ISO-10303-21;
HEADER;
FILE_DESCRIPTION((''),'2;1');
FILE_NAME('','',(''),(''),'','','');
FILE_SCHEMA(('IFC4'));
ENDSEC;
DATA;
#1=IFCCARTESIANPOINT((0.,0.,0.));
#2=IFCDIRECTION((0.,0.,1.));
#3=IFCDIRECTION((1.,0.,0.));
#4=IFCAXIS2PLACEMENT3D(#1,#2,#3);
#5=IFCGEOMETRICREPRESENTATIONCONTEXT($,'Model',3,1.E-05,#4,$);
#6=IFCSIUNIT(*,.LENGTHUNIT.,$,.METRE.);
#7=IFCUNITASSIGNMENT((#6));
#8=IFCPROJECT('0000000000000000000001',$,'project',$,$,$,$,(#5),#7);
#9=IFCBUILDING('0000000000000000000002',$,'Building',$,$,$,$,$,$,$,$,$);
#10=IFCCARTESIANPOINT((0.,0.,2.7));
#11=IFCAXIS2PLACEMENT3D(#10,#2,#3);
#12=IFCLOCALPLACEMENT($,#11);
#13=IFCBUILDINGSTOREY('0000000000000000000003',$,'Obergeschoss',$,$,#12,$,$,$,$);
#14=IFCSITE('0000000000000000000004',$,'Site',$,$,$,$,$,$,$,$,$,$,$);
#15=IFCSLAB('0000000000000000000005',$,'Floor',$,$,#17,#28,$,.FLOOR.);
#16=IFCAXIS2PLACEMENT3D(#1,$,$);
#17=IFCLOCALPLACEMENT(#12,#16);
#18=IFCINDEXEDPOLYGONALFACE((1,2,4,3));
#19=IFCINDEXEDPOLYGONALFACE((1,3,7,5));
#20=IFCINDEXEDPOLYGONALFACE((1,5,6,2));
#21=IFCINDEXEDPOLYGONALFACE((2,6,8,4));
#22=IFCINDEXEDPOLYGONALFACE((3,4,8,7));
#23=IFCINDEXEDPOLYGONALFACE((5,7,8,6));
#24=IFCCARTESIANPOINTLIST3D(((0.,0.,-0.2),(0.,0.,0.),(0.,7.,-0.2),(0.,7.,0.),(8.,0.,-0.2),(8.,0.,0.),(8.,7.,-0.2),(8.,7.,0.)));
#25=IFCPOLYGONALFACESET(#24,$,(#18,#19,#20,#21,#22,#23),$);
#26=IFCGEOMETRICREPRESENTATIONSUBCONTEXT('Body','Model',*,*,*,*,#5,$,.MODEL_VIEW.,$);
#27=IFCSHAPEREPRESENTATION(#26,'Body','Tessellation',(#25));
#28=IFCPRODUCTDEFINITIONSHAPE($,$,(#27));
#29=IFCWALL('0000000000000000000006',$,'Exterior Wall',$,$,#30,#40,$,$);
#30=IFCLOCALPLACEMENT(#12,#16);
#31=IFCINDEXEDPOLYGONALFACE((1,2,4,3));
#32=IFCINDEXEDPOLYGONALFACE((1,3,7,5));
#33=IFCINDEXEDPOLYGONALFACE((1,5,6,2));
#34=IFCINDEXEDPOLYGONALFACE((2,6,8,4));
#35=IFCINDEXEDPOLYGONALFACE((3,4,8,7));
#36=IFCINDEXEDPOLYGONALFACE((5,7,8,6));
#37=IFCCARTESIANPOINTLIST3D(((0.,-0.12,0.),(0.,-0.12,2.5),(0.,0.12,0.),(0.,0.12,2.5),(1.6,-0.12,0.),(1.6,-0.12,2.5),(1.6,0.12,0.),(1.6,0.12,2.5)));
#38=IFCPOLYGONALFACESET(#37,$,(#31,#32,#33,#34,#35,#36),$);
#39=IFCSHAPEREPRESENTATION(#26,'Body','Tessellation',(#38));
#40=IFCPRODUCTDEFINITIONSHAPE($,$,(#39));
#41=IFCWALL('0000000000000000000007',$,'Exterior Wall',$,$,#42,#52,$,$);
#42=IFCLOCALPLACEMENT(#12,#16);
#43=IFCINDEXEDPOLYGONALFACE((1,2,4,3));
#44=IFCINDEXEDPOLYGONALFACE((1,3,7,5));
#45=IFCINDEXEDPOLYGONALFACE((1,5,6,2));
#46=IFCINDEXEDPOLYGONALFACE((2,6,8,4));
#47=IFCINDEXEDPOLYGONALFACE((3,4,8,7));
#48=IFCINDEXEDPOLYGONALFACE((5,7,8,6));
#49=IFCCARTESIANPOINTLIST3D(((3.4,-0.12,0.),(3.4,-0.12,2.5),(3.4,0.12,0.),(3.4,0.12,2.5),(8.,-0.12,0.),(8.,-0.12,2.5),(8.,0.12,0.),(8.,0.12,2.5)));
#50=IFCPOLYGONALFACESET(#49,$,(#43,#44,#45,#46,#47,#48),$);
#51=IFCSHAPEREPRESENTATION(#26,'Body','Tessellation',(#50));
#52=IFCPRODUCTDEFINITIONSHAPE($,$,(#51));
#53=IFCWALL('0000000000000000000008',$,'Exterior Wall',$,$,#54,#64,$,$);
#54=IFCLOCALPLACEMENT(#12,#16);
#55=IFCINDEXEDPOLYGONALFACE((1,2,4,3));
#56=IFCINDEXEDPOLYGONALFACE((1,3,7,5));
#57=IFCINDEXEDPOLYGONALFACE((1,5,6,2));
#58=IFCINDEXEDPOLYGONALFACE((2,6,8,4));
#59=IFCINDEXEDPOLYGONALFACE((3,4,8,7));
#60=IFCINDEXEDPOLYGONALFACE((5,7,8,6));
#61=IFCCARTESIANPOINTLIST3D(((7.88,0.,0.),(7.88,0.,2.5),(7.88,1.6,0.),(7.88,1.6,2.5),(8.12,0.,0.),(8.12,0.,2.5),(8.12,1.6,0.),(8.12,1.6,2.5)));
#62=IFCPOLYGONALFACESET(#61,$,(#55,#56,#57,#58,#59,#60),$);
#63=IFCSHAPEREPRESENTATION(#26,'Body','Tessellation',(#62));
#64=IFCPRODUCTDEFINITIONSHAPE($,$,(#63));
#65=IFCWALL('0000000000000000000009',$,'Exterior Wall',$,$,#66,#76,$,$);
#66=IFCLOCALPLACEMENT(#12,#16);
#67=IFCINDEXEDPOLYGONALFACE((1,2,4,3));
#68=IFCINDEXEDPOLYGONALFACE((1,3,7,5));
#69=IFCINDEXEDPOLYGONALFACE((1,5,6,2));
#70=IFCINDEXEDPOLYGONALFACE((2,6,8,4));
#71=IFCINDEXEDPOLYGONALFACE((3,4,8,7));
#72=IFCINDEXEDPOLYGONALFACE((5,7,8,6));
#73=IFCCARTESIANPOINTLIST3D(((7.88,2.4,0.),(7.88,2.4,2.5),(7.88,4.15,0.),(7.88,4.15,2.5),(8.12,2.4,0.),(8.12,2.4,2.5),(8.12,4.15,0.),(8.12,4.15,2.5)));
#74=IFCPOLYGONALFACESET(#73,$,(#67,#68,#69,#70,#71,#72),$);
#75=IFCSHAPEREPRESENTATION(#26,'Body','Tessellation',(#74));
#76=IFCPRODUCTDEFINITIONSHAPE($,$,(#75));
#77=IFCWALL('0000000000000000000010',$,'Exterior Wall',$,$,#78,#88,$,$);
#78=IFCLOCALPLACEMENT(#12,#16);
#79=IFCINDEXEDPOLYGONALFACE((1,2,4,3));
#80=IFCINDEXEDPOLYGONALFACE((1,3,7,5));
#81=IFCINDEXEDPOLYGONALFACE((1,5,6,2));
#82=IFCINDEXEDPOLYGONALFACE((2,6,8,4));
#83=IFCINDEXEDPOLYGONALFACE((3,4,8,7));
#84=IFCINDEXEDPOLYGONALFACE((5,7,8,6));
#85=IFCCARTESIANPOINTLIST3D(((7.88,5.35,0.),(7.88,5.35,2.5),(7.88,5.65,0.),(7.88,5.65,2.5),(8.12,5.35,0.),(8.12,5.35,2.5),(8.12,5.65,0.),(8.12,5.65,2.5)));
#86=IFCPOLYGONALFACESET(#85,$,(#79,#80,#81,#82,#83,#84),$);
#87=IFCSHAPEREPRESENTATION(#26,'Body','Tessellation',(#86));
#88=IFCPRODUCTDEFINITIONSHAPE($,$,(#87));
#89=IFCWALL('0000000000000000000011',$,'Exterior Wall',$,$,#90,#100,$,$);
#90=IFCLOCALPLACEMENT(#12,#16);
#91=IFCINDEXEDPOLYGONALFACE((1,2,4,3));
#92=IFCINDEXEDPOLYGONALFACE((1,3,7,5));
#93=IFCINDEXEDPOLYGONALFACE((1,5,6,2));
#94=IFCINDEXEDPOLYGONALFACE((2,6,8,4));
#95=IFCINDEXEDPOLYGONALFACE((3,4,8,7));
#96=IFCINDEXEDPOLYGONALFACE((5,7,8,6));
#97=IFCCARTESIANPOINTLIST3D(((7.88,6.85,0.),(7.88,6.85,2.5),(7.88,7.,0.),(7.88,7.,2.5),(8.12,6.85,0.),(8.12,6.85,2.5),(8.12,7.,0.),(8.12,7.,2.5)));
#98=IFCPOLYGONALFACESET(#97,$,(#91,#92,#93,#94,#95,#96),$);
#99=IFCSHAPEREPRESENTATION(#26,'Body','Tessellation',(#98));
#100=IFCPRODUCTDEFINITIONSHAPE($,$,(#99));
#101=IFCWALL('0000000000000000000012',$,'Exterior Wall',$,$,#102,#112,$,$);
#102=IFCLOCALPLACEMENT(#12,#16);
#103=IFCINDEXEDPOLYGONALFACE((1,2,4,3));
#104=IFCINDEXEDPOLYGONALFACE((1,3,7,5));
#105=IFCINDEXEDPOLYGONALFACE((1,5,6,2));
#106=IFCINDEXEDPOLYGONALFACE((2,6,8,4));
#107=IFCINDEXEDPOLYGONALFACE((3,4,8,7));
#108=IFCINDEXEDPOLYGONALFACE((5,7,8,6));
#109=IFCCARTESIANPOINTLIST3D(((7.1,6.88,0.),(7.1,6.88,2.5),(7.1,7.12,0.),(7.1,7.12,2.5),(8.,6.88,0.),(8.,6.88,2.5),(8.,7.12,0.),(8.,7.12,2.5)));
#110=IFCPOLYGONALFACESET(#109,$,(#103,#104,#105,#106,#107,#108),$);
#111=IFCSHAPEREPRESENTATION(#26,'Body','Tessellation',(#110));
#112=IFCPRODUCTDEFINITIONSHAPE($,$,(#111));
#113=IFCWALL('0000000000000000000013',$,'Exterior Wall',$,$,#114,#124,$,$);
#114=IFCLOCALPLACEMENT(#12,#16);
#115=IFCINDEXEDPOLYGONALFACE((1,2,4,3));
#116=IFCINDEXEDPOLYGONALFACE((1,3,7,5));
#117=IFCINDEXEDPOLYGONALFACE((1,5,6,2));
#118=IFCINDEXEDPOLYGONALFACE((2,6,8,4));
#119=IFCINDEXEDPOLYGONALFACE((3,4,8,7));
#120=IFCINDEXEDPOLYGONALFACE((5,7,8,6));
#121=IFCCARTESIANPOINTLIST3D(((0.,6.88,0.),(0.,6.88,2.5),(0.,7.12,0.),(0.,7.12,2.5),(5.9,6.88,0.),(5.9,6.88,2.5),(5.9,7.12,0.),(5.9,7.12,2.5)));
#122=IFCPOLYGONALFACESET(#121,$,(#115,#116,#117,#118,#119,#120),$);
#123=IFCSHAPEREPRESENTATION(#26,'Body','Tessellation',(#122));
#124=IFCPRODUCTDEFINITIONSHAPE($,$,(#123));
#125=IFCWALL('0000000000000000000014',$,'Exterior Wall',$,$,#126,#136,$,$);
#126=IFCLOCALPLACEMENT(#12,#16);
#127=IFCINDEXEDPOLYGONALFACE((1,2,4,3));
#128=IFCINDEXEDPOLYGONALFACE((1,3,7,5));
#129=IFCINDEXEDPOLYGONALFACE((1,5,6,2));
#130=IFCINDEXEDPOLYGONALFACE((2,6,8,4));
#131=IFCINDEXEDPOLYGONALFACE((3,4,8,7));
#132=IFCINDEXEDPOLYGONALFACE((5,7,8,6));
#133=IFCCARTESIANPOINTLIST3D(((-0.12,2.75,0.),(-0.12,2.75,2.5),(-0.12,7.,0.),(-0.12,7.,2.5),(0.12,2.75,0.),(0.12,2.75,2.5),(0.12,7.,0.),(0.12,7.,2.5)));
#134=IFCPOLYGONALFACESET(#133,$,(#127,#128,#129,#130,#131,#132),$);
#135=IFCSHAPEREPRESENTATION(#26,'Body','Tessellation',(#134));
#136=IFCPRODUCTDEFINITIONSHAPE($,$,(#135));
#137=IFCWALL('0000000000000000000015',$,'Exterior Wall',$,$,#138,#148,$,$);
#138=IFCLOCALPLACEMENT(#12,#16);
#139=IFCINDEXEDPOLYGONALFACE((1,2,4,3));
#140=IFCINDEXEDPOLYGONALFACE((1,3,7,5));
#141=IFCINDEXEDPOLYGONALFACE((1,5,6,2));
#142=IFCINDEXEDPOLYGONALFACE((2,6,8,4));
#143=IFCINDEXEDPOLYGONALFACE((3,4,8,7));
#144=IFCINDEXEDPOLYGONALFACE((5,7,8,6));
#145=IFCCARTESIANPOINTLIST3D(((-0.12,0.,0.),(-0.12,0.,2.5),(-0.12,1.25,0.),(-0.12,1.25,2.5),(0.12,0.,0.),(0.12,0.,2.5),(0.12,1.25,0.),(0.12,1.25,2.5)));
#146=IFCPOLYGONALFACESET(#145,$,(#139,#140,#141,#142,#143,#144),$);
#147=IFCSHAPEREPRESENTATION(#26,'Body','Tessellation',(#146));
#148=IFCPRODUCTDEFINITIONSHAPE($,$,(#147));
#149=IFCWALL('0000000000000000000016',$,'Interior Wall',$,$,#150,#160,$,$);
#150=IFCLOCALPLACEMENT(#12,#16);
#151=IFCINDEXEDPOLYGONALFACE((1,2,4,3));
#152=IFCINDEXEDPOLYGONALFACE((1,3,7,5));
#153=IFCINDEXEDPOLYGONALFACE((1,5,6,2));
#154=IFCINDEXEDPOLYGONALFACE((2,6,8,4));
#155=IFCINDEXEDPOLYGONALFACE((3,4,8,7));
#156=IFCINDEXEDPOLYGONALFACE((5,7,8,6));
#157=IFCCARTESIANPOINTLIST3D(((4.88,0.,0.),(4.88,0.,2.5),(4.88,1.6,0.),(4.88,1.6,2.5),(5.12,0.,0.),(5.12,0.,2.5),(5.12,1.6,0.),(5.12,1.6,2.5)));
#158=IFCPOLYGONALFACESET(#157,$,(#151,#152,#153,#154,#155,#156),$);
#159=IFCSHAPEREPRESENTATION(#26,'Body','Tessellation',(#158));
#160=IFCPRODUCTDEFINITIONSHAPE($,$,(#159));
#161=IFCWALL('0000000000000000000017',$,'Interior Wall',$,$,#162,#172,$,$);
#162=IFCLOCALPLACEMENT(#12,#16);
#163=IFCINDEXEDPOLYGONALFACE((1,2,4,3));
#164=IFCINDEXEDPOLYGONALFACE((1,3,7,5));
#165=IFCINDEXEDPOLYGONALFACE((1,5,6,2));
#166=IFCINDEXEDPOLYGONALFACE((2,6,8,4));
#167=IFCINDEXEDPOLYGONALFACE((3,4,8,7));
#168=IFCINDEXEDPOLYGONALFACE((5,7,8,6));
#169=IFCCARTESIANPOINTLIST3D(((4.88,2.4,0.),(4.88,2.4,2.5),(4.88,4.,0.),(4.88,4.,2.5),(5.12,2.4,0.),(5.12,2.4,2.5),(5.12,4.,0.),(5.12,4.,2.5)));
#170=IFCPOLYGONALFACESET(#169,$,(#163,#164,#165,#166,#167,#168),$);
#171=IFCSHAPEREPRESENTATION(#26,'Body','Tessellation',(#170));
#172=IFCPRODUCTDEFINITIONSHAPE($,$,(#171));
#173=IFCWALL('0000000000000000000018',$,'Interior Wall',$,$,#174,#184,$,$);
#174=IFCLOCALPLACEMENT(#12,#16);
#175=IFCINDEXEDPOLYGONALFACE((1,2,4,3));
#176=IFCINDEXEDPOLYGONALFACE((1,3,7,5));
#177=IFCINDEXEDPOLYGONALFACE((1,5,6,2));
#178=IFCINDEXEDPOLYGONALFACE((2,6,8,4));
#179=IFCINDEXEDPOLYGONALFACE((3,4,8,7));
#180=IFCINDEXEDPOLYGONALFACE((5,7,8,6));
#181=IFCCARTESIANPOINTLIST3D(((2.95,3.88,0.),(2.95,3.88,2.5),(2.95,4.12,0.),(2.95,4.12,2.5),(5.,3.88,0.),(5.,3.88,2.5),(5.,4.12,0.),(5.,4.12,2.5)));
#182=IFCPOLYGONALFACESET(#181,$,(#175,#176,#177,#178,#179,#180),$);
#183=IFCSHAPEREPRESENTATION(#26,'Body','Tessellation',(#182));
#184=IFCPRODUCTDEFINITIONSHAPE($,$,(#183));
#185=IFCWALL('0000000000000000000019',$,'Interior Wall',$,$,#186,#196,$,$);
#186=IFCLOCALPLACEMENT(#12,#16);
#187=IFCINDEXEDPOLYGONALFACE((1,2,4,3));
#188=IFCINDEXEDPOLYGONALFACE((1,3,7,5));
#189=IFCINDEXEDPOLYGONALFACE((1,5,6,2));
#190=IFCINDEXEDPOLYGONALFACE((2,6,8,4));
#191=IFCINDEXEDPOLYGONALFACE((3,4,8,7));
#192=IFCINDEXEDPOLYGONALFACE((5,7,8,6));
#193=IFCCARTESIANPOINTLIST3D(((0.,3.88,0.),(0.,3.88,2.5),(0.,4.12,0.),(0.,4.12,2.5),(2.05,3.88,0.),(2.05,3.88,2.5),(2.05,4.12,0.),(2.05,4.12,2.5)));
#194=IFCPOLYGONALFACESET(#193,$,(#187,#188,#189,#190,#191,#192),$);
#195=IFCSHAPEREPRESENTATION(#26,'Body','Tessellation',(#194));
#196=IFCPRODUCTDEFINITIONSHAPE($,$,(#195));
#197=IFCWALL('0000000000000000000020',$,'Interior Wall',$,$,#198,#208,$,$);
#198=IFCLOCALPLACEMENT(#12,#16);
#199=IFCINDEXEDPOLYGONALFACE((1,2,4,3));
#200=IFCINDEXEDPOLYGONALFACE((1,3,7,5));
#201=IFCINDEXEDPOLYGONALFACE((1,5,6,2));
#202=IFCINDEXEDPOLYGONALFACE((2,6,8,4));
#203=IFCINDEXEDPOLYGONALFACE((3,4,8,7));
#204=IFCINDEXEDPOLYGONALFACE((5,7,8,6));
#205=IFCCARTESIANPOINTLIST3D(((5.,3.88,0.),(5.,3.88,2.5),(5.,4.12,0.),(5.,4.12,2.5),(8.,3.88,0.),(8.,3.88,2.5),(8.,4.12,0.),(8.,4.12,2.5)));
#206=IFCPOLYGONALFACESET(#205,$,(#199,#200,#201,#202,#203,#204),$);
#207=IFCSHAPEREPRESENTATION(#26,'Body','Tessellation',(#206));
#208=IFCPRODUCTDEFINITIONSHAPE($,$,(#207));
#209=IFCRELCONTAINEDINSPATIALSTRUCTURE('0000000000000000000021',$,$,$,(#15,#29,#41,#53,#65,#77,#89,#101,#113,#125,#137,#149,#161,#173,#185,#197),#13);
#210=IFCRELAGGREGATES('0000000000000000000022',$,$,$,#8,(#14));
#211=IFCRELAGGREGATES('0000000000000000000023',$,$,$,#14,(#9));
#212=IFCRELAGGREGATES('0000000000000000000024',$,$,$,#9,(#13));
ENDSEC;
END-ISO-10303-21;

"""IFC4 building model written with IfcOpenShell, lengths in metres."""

from ifc_helpers import new_model, si_unit, frame, origin_with_axes, place, context, subcontext, project, spatial, indexed_curve, outline, extrude, element, save


model = new_model("IFC4")

# Units and contexts
model_context = context("Model", 3, precision=1e-05, world=origin_with_axes())
body_context = subcontext(model_context, "Body", "Model", "MODEL_VIEW")
ifc_project = project(units=[si_unit("LENGTHUNIT", "METRE")], contexts=[model_context])

# Site, building, storey
site = spatial("IfcSite", under=ifc_project, Name="Site")
building = spatial("IfcBuilding", under=site, Name="Building")
storey_placement = place(None, frame((0.0, 0.0, 2.7), z_axis=(0.0, 0.0, 1.0), x_axis=(1.0, 0.0, 0.0)))
storey = spatial("IfcBuildingStorey", under=building, at=storey_placement, Name="Obergeschoss")

# Slab
slab_placement = place(storey_placement, frame((0.0, 0.0, -0.2), z_axis=(0.0, 0.0, 1.0), x_axis=(1.0, 0.0, 0.0)))
element("IfcSlab", 1, at=slab_placement, inside=storey, Name="Floor", PredefinedType="FLOOR", context=body_context, shape_type="SweptSolid", body=[
    extrude(outline(indexed_curve([(0.0, 0.0), (8.0, 0.0), (8.0, 7.0), (0.0, 7.0)])), None, (0.0, 0.0, 1.0), 0.2),
])

# Walls
wall_1_placement = place(storey_placement, origin_with_axes())
element("IfcWall", 2, at=wall_1_placement, inside=storey, Name="Exterior Wall", context=body_context, shape_type="SweptSolid", body=[
    extrude(outline(indexed_curve([(0.0, 0.0), (0.0, 0.24), (1.6, 0.24), (1.6, 0.0), (0.0, 0.0)], self_intersect=False)), frame((0.0, -0.12, 0.0), z_axis=(0.0, 0.0, 1.0), x_axis=(1.0, 0.0, 0.0)), (0.0, 0.0, 1.0), 2.5),
])
wall_2_placement = place(storey_placement, frame((3.4, 0.0, 0.0), z_axis=(0.0, 0.0, 1.0), x_axis=(1.0, 0.0, 0.0)))
element("IfcWall", 3, at=wall_2_placement, inside=storey, Name="Exterior Wall", context=body_context, shape_type="SweptSolid", body=[
    extrude(outline(indexed_curve([(0.0, 0.0), (0.0, 0.24), (4.6, 0.24), (4.6, 0.0), (0.0, 0.0)], self_intersect=False)), frame((0.0, -0.12, 0.0), z_axis=(0.0, 0.0, 1.0), x_axis=(1.0, 0.0, 0.0)), (0.0, 0.0, 1.0), 2.5),
])
wall_3_placement = place(storey_placement, frame((8.0, 0.0, 0.0), z_axis=(0.0, 0.0, 1.0), x_axis=(0.0, 1.0, 0.0)))
element("IfcWall", 4, at=wall_3_placement, inside=storey, Name="Exterior Wall", context=body_context, shape_type="SweptSolid", body=[
    extrude(outline(indexed_curve([(0.0, 0.0), (0.0, 0.24), (1.6, 0.24), (1.6, 0.0), (0.0, 0.0)], self_intersect=False)), frame((0.0, -0.12, 0.0), z_axis=(0.0, 0.0, 1.0), x_axis=(1.0, 0.0, 0.0)), (0.0, 0.0, 1.0), 2.5),
])
wall_4_placement = place(storey_placement, frame((8.0, 2.4, 0.0), z_axis=(0.0, 0.0, 1.0), x_axis=(0.0, 1.0, 0.0)))
element("IfcWall", 5, at=wall_4_placement, inside=storey, Name="Exterior Wall", context=body_context, shape_type="SweptSolid", body=[
    extrude(outline(indexed_curve([(0.0, 0.0), (0.0, 0.24), (1.75, 0.24), (1.75, 0.0), (0.0, 0.0)], self_intersect=False)), frame((0.0, -0.12, 0.0), z_axis=(0.0, 0.0, 1.0), x_axis=(1.0, 0.0, 0.0)), (0.0, 0.0, 1.0), 2.5),
])
wall_5_placement = place(storey_placement, frame((8.0, 5.35, 0.0), z_axis=(0.0, 0.0, 1.0), x_axis=(0.0, 1.0, 0.0)))
element("IfcWall", 6, at=wall_5_placement, inside=storey, Name="Exterior Wall", context=body_context, shape_type="SweptSolid", body=[
    extrude(outline(indexed_curve([(0.0, 0.0), (0.0, 0.24), (0.3, 0.24), (0.3, 0.0), (0.0, 0.0)], self_intersect=False)), frame((0.0, -0.12, 0.0), z_axis=(0.0, 0.0, 1.0), x_axis=(1.0, 0.0, 0.0)), (0.0, 0.0, 1.0), 2.5),
])
wall_6_placement = place(storey_placement, frame((8.0, 6.85, 0.0), z_axis=(0.0, 0.0, 1.0), x_axis=(0.0, 1.0, 0.0)))
element("IfcWall", 7, at=wall_6_placement, inside=storey, Name="Exterior Wall", context=body_context, shape_type="SweptSolid", body=[
    extrude(outline(indexed_curve([(0.0, 0.0), (0.0, 0.24), (0.15, 0.24), (0.15, 0.0), (0.0, 0.0)], self_intersect=False)), frame((0.0, -0.12, 0.0), z_axis=(0.0, 0.0, 1.0), x_axis=(1.0, 0.0, 0.0)), (0.0, 0.0, 1.0), 2.5),
])
wall_7_placement = place(storey_placement, frame((8.0, 7.0, 0.0), z_axis=(0.0, 0.0, 1.0), x_axis=(-1.0, 0.0, 0.0)))
element("IfcWall", 8, at=wall_7_placement, inside=storey, Name="Exterior Wall", context=body_context, shape_type="SweptSolid", body=[
    extrude(outline(indexed_curve([(0.0, 0.0), (0.0, 0.24), (0.9, 0.24), (0.9, 0.0), (0.0, 0.0)], self_intersect=False)), frame((0.0, -0.12, 0.0), z_axis=(0.0, 0.0, 1.0), x_axis=(1.0, 0.0, 0.0)), (0.0, 0.0, 1.0), 2.5),
])
wall_8_placement = place(storey_placement, frame((5.9, 7.0, 0.0), z_axis=(0.0, 0.0, 1.0), x_axis=(-1.0, 0.0, 0.0)))
element("IfcWall", 9, at=wall_8_placement, inside=storey, Name="Exterior Wall", context=body_context, shape_type="SweptSolid", body=[
    extrude(outline(indexed_curve([(0.0, 0.0), (0.0, 0.24), (5.9, 0.24), (5.9, 0.0), (0.0, 0.0)], self_intersect=False)), frame((0.0, -0.12, 0.0), z_axis=(0.0, 0.0, 1.0), x_axis=(1.0, 0.0, 0.0)), (0.0, 0.0, 1.0), 2.5),
])
wall_9_placement = place(storey_placement, frame((0.0, 7.0, 0.0), z_axis=(0.0, 0.0, 1.0), x_axis=(0.0, -1.0, 0.0)))
element("IfcWall", 10, at=wall_9_placement, inside=storey, Name="Exterior Wall", context=body_context, shape_type="SweptSolid", body=[
    extrude(outline(indexed_curve([(0.0, 0.0), (0.0, 0.24), (4.25, 0.24), (4.25, 0.0), (0.0, 0.0)], self_intersect=False)), frame((0.0, -0.12, 0.0), z_axis=(0.0, 0.0, 1.0), x_axis=(1.0, 0.0, 0.0)), (0.0, 0.0, 1.0), 2.5),
])
wall_10_placement = place(storey_placement, frame((0.0, 1.25, 0.0), z_axis=(0.0, 0.0, 1.0), x_axis=(0.0, -1.0, 0.0)))
element("IfcWall", 11, at=wall_10_placement, inside=storey, Name="Exterior Wall", context=body_context, shape_type="SweptSolid", body=[
    extrude(outline(indexed_curve([(0.0, 0.0), (0.0, 0.24), (1.25, 0.24), (1.25, 0.0), (0.0, 0.0)], self_intersect=False)), frame((0.0, -0.12, 0.0), z_axis=(0.0, 0.0, 1.0), x_axis=(1.0, 0.0, 0.0)), (0.0, 0.0, 1.0), 2.5),
])
for number, where, z_axis, x_axis, name in (
    (12, (5.0, 0.0, 0.0), (0.0, 0.0, 1.0), (0.0, 1.0, 0.0), "Interior Wall"),
    (13, (5.0, 2.4, 0.0), (0.0, 0.0, 1.0), (0.0, 1.0, 0.0), "Interior Wall"),
):
    element("IfcWall", number, at=place(storey_placement, frame(where, z_axis=z_axis, x_axis=x_axis)), inside=storey, Name=name, context=body_context, shape_type="SweptSolid", body=[
        extrude(outline(indexed_curve([(0.0, 0.0), (0.0, 0.24), (1.6, 0.24), (1.6, 0.0), (0.0, 0.0)], self_intersect=False)), frame((0.0, -0.12, 0.0), z_axis=(0.0, 0.0, 1.0), x_axis=(1.0, 0.0, 0.0)), (0.0, 0.0, 1.0), 2.5),
    ])
for number, where, z_axis, x_axis, name in (
    (14, (5.0, 4.0, 0.0), (0.0, 0.0, 1.0), (-1.0, 0.0, 0.0), "Interior Wall"),
    (15, (2.05, 4.0, 0.0), (0.0, 0.0, 1.0), (-1.0, 0.0, 0.0), "Interior Wall"),
):
    element("IfcWall", number, at=place(storey_placement, frame(where, z_axis=z_axis, x_axis=x_axis)), inside=storey, Name=name, context=body_context, shape_type="SweptSolid", body=[
        extrude(outline(indexed_curve([(0.0, 0.0), (0.0, 0.24), (2.05, 0.24), (2.05, 0.0), (0.0, 0.0)], self_intersect=False)), frame((0.0, -0.12, 0.0), z_axis=(0.0, 0.0, 1.0), x_axis=(1.0, 0.0, 0.0)), (0.0, 0.0, 1.0), 2.5),
    ])
wall_11_placement = place(storey_placement, frame((8.0, 4.0, 0.0), z_axis=(0.0, 0.0, 1.0), x_axis=(-1.0, 0.0, 0.0)))
element("IfcWall", 16, at=wall_11_placement, inside=storey, Name="Interior Wall", context=body_context, shape_type="SweptSolid", body=[
    extrude(outline(indexed_curve([(0.0, 0.0), (0.0, 0.24), (3.0, 0.24), (3.0, 0.0), (0.0, 0.0)], self_intersect=False)), frame((0.0, -0.12, 0.0), z_axis=(0.0, 0.0, 1.0), x_axis=(1.0, 0.0, 0.0)), (0.0, 0.0, 1.0), 2.5),
])

save(model, "model.ifc")
